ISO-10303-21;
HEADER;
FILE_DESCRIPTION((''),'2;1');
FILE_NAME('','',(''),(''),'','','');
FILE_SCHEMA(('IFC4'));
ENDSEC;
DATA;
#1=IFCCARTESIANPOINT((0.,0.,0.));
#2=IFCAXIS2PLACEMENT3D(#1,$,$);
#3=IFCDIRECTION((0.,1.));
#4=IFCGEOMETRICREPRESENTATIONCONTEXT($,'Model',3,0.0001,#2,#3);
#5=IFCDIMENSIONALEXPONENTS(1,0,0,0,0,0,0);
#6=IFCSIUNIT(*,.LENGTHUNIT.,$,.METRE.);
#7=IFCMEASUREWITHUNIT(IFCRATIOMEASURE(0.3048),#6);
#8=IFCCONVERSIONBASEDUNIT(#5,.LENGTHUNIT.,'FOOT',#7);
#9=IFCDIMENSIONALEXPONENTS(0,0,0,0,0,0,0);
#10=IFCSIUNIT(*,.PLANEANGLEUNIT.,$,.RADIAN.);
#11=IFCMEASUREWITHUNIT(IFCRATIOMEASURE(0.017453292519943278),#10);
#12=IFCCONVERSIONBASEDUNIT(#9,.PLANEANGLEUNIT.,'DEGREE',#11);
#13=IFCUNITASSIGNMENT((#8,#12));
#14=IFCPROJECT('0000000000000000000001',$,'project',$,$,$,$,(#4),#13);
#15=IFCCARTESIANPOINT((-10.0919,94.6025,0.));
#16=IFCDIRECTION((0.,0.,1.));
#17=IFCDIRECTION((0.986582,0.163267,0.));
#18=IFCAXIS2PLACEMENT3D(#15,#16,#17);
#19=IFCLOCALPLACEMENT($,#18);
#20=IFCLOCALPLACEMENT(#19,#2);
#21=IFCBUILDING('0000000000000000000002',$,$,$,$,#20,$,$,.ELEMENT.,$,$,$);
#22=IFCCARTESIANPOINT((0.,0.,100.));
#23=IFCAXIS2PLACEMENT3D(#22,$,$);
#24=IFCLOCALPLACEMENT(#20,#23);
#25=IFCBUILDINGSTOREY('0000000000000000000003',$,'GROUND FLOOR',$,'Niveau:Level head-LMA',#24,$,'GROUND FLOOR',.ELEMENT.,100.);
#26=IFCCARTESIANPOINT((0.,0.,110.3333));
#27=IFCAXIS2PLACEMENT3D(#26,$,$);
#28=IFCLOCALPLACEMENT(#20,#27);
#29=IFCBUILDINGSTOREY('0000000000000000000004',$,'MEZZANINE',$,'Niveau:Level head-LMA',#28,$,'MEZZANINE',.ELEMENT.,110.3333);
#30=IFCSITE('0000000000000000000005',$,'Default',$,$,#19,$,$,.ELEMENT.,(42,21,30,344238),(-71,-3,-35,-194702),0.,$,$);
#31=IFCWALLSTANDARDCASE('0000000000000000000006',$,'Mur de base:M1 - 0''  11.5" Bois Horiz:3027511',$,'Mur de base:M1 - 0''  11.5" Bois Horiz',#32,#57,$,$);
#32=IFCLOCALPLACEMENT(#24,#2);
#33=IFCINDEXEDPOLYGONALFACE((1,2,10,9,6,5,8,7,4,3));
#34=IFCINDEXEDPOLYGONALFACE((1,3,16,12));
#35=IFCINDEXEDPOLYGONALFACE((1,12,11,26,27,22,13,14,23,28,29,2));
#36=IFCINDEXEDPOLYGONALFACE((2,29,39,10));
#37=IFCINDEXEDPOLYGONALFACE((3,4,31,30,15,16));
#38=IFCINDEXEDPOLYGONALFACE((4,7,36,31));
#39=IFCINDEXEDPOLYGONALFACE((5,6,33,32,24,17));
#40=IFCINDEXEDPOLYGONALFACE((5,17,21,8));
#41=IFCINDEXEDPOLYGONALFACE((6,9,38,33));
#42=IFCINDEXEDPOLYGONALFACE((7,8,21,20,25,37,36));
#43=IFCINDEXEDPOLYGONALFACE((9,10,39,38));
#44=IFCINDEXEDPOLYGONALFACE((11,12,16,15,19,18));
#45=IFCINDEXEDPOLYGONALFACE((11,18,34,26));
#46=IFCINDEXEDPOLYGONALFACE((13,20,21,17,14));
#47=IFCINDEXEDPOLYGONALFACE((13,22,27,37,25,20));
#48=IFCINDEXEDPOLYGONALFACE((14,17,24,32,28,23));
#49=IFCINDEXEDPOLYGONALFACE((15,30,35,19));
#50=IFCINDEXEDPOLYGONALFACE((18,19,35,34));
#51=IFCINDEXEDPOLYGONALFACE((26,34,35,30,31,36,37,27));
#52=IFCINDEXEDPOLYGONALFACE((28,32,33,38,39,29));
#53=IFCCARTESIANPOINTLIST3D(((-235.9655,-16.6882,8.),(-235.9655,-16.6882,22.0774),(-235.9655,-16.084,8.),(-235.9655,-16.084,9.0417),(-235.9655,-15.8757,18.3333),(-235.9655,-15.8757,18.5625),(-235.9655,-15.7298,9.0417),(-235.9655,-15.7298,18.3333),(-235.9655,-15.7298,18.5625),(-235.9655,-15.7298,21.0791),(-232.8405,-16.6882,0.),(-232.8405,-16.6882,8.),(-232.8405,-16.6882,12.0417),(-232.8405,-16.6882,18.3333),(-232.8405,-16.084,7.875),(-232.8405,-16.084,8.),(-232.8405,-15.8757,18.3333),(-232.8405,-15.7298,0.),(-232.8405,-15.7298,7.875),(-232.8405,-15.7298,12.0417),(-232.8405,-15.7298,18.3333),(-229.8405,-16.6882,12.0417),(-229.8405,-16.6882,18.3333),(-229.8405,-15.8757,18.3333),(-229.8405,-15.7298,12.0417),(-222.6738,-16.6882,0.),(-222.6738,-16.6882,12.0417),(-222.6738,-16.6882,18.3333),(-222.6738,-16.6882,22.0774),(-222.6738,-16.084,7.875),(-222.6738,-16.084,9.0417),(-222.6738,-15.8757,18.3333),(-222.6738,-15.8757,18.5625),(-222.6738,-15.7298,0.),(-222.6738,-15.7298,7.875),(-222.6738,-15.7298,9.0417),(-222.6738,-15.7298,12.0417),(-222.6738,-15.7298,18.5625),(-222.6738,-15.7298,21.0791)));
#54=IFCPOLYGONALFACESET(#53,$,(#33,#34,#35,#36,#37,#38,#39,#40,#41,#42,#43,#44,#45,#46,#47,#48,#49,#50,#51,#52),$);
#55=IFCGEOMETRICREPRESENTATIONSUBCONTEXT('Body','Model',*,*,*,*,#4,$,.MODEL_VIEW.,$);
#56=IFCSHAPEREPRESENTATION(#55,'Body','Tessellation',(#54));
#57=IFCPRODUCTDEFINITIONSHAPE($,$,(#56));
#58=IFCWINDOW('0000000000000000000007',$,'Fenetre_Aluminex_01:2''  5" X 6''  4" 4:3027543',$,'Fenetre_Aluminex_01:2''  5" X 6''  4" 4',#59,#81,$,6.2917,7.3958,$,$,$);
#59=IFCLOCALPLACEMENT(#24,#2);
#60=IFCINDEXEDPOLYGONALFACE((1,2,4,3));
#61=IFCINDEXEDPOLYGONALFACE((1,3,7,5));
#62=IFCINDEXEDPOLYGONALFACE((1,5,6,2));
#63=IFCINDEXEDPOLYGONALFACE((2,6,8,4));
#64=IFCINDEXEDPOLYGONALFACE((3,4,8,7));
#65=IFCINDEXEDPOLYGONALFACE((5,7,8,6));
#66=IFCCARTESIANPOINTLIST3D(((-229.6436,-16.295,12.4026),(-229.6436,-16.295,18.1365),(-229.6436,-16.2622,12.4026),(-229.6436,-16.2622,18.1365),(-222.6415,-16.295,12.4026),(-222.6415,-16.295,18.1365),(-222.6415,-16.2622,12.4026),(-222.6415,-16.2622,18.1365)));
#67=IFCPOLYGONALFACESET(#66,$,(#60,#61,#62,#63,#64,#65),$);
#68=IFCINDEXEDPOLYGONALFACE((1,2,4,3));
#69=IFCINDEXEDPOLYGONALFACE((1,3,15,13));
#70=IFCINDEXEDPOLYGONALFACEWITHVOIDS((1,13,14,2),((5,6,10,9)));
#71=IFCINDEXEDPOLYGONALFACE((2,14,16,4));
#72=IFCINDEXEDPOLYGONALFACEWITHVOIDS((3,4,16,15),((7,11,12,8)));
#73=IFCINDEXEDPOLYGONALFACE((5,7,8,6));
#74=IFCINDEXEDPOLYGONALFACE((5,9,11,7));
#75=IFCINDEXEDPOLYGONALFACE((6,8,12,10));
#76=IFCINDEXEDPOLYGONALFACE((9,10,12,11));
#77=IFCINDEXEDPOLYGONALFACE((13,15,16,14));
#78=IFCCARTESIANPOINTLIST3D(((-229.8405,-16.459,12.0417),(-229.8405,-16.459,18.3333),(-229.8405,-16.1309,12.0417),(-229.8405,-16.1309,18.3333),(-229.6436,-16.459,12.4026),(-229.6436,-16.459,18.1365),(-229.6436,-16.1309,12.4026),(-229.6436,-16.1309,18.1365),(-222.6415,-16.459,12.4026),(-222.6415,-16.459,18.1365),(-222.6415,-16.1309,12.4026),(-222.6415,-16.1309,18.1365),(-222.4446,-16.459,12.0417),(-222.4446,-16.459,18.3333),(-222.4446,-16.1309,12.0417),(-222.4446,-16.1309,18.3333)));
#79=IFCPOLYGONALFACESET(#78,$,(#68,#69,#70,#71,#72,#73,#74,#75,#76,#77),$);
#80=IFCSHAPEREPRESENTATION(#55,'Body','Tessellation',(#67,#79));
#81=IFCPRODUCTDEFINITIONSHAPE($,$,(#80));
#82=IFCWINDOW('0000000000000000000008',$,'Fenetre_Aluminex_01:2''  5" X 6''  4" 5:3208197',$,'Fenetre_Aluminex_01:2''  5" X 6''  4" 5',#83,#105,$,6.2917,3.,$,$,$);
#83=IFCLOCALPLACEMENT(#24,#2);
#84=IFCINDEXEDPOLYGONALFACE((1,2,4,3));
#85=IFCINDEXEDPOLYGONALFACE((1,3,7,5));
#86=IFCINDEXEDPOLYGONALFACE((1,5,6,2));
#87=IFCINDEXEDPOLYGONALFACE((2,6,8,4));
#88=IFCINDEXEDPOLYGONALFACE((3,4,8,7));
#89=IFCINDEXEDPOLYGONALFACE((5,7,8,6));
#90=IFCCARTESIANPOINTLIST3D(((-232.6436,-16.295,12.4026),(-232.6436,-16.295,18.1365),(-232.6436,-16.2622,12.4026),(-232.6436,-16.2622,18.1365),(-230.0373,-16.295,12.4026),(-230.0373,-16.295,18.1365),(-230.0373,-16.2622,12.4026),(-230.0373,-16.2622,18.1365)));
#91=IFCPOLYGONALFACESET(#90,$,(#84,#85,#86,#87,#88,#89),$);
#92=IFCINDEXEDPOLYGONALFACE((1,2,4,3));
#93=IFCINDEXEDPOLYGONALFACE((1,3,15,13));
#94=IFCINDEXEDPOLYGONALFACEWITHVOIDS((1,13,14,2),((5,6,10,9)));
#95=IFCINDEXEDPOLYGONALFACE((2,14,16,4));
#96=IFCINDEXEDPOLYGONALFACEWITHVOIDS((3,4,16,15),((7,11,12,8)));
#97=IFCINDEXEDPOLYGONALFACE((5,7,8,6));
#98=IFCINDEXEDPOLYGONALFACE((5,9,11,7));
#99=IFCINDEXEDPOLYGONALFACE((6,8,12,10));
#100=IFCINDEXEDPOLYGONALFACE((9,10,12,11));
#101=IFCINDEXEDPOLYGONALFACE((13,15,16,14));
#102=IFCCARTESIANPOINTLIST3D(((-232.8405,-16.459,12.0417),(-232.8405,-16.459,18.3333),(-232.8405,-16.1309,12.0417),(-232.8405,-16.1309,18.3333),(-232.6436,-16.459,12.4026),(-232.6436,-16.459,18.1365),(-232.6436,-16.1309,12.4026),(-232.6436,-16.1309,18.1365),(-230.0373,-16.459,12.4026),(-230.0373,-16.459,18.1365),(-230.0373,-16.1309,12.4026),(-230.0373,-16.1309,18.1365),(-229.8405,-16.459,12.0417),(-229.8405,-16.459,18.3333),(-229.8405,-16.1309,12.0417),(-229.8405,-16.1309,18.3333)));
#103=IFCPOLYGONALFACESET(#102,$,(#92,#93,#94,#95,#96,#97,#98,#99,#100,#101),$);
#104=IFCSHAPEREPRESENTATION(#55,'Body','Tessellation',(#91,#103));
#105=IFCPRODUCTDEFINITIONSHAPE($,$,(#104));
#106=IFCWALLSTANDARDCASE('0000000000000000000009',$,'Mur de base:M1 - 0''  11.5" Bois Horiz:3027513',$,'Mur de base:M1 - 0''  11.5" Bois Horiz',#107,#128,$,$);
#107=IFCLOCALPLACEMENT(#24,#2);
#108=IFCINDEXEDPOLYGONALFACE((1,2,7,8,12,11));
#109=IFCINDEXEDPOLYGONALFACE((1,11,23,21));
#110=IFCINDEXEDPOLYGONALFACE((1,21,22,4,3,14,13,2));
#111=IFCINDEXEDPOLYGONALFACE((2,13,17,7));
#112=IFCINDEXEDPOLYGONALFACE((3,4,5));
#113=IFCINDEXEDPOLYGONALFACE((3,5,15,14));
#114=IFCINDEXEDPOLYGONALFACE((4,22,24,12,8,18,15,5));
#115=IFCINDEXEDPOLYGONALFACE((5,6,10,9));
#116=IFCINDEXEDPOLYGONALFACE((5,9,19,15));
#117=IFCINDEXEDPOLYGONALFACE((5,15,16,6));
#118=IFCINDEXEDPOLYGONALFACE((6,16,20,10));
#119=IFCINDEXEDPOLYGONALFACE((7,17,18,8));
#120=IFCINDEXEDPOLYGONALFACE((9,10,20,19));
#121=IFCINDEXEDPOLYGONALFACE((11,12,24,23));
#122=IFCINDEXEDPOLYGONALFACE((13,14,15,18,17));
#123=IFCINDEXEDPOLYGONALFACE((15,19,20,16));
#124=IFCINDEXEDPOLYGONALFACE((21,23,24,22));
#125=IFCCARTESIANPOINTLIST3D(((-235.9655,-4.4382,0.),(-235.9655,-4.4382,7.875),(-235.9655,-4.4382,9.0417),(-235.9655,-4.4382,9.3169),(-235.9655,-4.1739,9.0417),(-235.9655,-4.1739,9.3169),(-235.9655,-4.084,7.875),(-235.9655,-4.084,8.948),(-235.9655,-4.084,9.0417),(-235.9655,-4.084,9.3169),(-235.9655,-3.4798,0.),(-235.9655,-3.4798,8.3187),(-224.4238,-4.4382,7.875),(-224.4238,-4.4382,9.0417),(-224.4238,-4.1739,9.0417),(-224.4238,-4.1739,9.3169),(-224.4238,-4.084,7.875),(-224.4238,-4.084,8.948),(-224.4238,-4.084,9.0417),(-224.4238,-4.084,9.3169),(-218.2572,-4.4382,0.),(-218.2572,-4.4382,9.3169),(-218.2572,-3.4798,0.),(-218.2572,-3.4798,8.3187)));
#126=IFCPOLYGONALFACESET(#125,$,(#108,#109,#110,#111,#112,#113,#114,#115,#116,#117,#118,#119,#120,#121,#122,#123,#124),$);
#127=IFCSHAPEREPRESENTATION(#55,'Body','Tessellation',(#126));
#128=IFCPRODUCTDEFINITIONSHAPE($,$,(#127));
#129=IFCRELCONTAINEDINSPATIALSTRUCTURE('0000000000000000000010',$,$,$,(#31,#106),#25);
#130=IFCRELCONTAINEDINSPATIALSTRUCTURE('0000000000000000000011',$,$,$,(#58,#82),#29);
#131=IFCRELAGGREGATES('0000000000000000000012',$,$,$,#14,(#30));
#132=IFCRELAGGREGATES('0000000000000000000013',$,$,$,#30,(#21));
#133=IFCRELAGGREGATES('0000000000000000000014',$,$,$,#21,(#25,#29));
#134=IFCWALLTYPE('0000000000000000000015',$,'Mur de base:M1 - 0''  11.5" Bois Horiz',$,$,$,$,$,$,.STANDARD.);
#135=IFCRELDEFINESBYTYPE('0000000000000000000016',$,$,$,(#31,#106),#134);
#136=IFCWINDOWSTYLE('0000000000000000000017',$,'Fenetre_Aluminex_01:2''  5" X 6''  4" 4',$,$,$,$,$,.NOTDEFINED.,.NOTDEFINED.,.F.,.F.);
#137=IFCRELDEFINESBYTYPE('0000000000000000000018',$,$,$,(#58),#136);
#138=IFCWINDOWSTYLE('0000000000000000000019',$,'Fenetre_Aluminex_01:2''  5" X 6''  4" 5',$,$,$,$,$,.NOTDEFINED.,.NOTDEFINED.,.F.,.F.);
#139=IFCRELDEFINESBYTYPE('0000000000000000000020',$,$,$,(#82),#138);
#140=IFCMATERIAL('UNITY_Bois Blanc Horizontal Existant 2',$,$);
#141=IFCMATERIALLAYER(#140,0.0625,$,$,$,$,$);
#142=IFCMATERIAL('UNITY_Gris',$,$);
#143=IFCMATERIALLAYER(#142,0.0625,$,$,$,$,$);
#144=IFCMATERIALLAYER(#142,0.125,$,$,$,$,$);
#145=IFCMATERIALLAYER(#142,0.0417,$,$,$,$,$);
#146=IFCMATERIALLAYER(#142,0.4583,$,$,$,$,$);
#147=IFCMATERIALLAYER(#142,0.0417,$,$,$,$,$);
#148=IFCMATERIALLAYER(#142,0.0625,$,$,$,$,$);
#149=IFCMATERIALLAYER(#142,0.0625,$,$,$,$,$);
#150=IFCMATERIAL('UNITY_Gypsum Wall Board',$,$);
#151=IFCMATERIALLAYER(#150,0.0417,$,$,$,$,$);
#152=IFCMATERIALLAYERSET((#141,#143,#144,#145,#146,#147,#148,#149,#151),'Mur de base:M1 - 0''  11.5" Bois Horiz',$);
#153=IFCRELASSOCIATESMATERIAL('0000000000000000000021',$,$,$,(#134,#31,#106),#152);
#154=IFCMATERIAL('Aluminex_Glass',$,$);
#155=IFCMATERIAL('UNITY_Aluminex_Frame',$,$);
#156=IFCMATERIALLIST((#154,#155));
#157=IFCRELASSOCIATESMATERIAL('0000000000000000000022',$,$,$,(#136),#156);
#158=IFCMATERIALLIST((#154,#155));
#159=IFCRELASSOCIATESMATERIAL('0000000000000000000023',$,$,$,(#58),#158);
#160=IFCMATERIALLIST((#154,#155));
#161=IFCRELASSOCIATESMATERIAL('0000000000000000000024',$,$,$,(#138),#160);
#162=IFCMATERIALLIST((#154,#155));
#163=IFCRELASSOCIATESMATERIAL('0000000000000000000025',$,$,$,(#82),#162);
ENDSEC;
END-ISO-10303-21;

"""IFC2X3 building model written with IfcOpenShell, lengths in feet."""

from ifc_helpers import new_model, entity, si_unit, converted_unit, direction, frame, frame_2d, origin, place, context, subcontext, project, spatial, polyline, rectangle, outline, extrude, clip, bounded_halfspace, source, transform, mapped, material, material_list, layer, layer_set, layer_usage, type_object, type_shapes, element, fill, save


model = new_model("IFC2X3")

# Units and contexts
model_context = context("Model", 3, precision=0.0001, world=origin(), true_north=direction((0.0, 1.0)))
body_context = subcontext(model_context, "Body", "Model", "MODEL_VIEW")
ifc_project = project(units=[converted_unit("LENGTHUNIT", "FOOT", entity("IfcRatioMeasure", 0.3048), si_unit("LENGTHUNIT", "METRE"), dimensions=[1, 0, 0, 0, 0, 0, 0]), converted_unit("PLANEANGLEUNIT", "DEGREE", entity("IfcRatioMeasure", 0.017453292519943278), si_unit("PLANEANGLEUNIT", "RADIAN"), dimensions=[0, 0, 0, 0, 0, 0, 0])], contexts=[model_context])

# Site, building, storey
site_placement = place(None, frame((-10.0919, 94.6025, 0.0), z_axis=(0.0, 0.0, 1.0), x_axis=(0.986582, 0.163267, 0.0)))
site = spatial("IfcSite", under=ifc_project, at=site_placement, Name="Default", CompositionType="ELEMENT", RefLatitude=(42, 21, 30, 344238), RefLongitude=(-71, -3, -35, -194702), RefElevation=0.0)
building_placement = place(site_placement, origin())
building = spatial("IfcBuilding", under=site, at=building_placement, CompositionType="ELEMENT")
storey_1_placement = place(building_placement, frame((0.0, 0.0, 100.0)))
storey_1 = spatial("IfcBuildingStorey", under=building, at=storey_1_placement, Name="GROUND FLOOR", ObjectType="Niveau:Level head-LMA", LongName="GROUND FLOOR", CompositionType="ELEMENT", Elevation=100.0)

# Shared definitions
ifc_material_1 = material(Name="UNITY_Gris")
ifc_material_2 = material(Name="UNITY_Aluminex_Frame")

# Shared definitions
ifc_material_3 = material(Name="UNITY_Bois Blanc Horizontal Existant 2")
ifc_material_4 = material(Name="UNITY_Gypsum Wall Board")

# Wall, openings
ifc_layer_1 = layer(ifc_material_3, 0.0625)
ifc_layer_2 = layer(ifc_material_1, 0.0625)
ifc_layer_3 = layer(ifc_material_1, 0.125)
ifc_layer_4 = layer(ifc_material_1, 0.0417)
ifc_layer_5 = layer(ifc_material_1, 0.4583)
ifc_layer_6 = layer(ifc_material_1, 0.0417)
ifc_layer_7 = layer(ifc_material_1, 0.0625)
ifc_layer_8 = layer(ifc_material_1, 0.0625)
ifc_layer_9 = layer(ifc_material_4, 0.0417)
ifc_layer_set_1 = layer_set([ifc_layer_1, ifc_layer_2, ifc_layer_3, ifc_layer_4, ifc_layer_5, ifc_layer_6, ifc_layer_7, ifc_layer_8, ifc_layer_9], Name="Mur de base:M1 - 0'  11.5\" Bois Horiz")
ifc_layer_usage_1 = layer_usage(ifc_layer_set_1, "AXIS2", "NEGATIVE", 0.4792)
wall_type_1 = type_object("IfcWallType", Name="Mur de base:M1 - 0'  11.5\" Bois Horiz", PredefinedType="STANDARD", material=ifc_layer_set_1)
wall_1_placement = place(storey_1_placement, frame((-222.6738, -16.209, 0.0), z_axis=(0.0, 0.0, 1.0), x_axis=(-1.0, 0.0, 0.0)))
wall_1 = element("IfcWallStandardCase", 1, at=wall_1_placement, inside=storey_1, type_object=wall_type_1, material=ifc_layer_usage_1, Name="Mur de base:M1 - 0'  11.5\" Bois Horiz:3027511", ObjectType="Mur de base:M1 - 0'  11.5\" Bois Horiz", context=body_context, shape_type="Clipping", body=[
    clip(clip(clip(extrude(rectangle(XDim=13.2917, YDim=0.9583, at=frame_2d((6.6458, 0.0), x_axis=(-1.0, 0.0))), origin(), (0.0, 0.0, 1.0), 22.0774), bounded_halfspace(frame((0.0, -0.4792, 21.0791), z_axis=(0.0, -0.721387, 0.692532), x_axis=(1.0, 0.0, 0.0)), False, frame((0.0, -0.4792, 21.0791)), polyline([(0.0, 0.0), (13.2917, 0.0), (13.2917, 0.2708), (13.2917, 0.9583), (0.0, 0.9583), (0.0, 0.0)]))), bounded_halfspace(frame((13.2917, -0.125, 9.0417), z_axis=(0.0, 1.0, 0.0), x_axis=(0.0, 0.0, 1.0)), True, frame((13.2917, -0.125, 9.0417), z_axis=(0.0, 1.0, 0.0), x_axis=(0.0, 0.0, 1.0)), polyline([(0.0, 0.0), (-1.0417, 0.0), (-1.0417, -3.125), (-1.1667, -3.125), (-1.1667, -13.2917), (0.0, -13.2917), (0.0, 0.0)]))), bounded_halfspace(frame((10.1666, -0.3333, 18.3333), z_axis=(0.0, 1.0, 0.0), x_axis=(0.0, 0.0, -1.0)), True, frame((10.1666, -0.3333, 18.3333), z_axis=(0.0, 1.0, 0.0), x_axis=(0.0, 0.0, -1.0)), polyline([(0.0, 0.0), (0.0, 10.1666), (-0.2292, 10.1666), (-0.2292, -3.125), (0.0, -3.125), (0.0, 0.0)]))),
])
opening_1_placement = place(wall_1_placement, origin())
element("IfcOpeningElement", 2, at=opening_1_placement, cuts=wall_1, ObjectType="Opening", context=body_context, shape_type="SweptSolid", body=[
    extrude(rectangle(XDim=6.2917, YDim=0.6875, at=frame_2d((0.0, 0.0), x_axis=(0.0, 1.0))), frame((-0.3438, 0.25, 15.1875), z_axis=(0.0, 1.0, 0.0), x_axis=(1.0, 0.0, 0.0)), (0.0, 0.0, 1.0), 3.0),
])
opening_2_placement = place(wall_1_placement, origin())
element("IfcOpeningElement", 3, at=opening_2_placement, cuts=wall_1, ObjectType="Opening", context=body_context, shape_type="SweptSolid", body=[
    extrude(rectangle(XDim=8.0, YDim=0.6667, at=frame_2d((0.0, 0.0), x_axis=(0.0, 1.0))), frame((13.6666, -3.0, 4.0), z_axis=(0.0, 1.0, 0.0), x_axis=(-1.0, 0.0, 0.0)), (0.0, 0.0, 1.0), 2.875),
])
opening_3_placement = place(wall_1_placement, frame((-222.6738, -16.209, 0.0), z_axis=(0.0, 0.0, 1.0), x_axis=(-1.0, 0.0, 0.0)))
element("IfcOpeningElement", 4, at=opening_3_placement, cuts=wall_1, ObjectType="Opening", context=body_context, shape_type="SweptSolid", body=[
    extrude(rectangle(XDim=8.0, YDim=3.1667, at=frame_2d((0.0, 0.0), x_axis=(0.0, 1.0))), frame((-234.4238, -11.6882, 4.0), z_axis=(0.0, -1.0, 0.0), x_axis=(1.0, 0.0, 0.0)), (0.0, 0.0, 1.0), 10.0),
])
opening_4_placement = place(wall_1_placement, frame((-0.2292, -0.4792, 12.0417)))
opening_4 = element("IfcOpeningElement", 5, at=opening_4_placement, cuts=wall_1, ObjectType="Opening", context=body_context, shape_type="SweptSolid", body=[
    extrude(rectangle(XDim=6.2917, YDim=7.3958, at=frame_2d((3.1458, 3.6979), x_axis=(1.0, 0.0))), frame((0.0, 0.0, 0.0), z_axis=(0.0, 1.0, 0.0), x_axis=(0.0, 0.0, 1.0)), (0.0, 0.0, 1.0), 0.9583),
])
opening_5_placement = place(wall_1_placement, frame((7.1666, -0.4792, 12.0417)))
opening_5 = element("IfcOpeningElement", 6, at=opening_5_placement, cuts=wall_1, ObjectType="Opening", context=body_context, shape_type="SweptSolid", body=[
    extrude(rectangle(XDim=6.2917, YDim=3.0, at=frame_2d((3.1458, 1.5), x_axis=(1.0, 0.0))), frame((0.0, 0.0, 0.0), z_axis=(0.0, 1.0, 0.0), x_axis=(0.0, 0.0, 1.0)), (0.0, 0.0, 1.0), 0.9583),
])

# Shared definitions
storey_2_placement = place(building_placement, frame((0.0, 0.0, 110.3333)))
storey_2 = spatial("IfcBuildingStorey", under=building, at=storey_2_placement, Name="MEZZANINE", ObjectType="Niveau:Level head-LMA", LongName="MEZZANINE", CompositionType="ELEMENT", Elevation=110.3333)

# Windows
ifc_material_5 = material(Name="Aluminex_Glass")
ifc_material_list_1 = material_list([ifc_material_5, ifc_material_2])
ifc_material_list_2 = material_list([ifc_material_5, ifc_material_2])
window_style_1 = type_object("IfcWindowStyle", Name="Fenetre_Aluminex_01:2'  5\" X 6'  4\" 4", ConstructionType="NOTDEFINED", OperationType="NOTDEFINED", ParameterTakesPrecedence=False, Sizeable=False, material=ifc_material_list_2)
shared_shape_1 = source(origin(), body_context, "Body", "SweptSolid", [
    extrude(rectangle(XDim=0.0328, YDim=7.0021, at=frame_2d((0.0, 0.0), x_axis=(1.0, 0.0))), frame((3.6979, 0.5487, 0.3609), z_axis=(0.0, 0.0, 1.0), x_axis=(0.0, 1.0, 0.0)), (0.0, 0.0, 1.0), 5.7339),
    extrude(outline(polyline([(-3.6979, -3.1458), (3.6979, -3.1458), (3.6979, 3.1458), (-3.6979, 3.1458), (-3.6979, -3.1458)]), holes=[polyline([(-3.5011, -2.949), (-3.5011, 2.7849), (3.5011, 2.7849), (3.5011, -2.949), (-3.5011, -2.949)])]), frame((3.6979, 0.4011, 3.1458), z_axis=(0.0, 1.0, 0.0), x_axis=(1.0, 0.0, 0.0)), (0.0, 0.0, 1.0), 0.3281),
])
type_shapes(window_style_1, [shared_shape_1])
window_1_placement = place(opening_4_placement, origin())
window_1 = element("IfcWindow", 7, at=window_1_placement, inside=storey_2, type_object=window_style_1, material=ifc_material_list_1, Name="Fenetre_Aluminex_01:2'  5\" X 6'  4\" 4:3027543", ObjectType="Fenetre_Aluminex_01:2'  5\" X 6'  4\" 4", OverallHeight=6.2917, OverallWidth=7.3958, context=body_context, shape_type="MappedRepresentation", body=[
    mapped(shared_shape_1, transform((0.0, 0.0, 0.0), scale=1.0)),
])
fill(opening_4, window_1)
ifc_material_list_3 = material_list([ifc_material_5, ifc_material_2])
ifc_material_list_4 = material_list([ifc_material_5, ifc_material_2])
window_style_2 = type_object("IfcWindowStyle", Name="Fenetre_Aluminex_01:2'  5\" X 6'  4\" 5", ConstructionType="NOTDEFINED", OperationType="NOTDEFINED", ParameterTakesPrecedence=False, Sizeable=False, material=ifc_material_list_4)
shared_shape_2 = source(origin(), body_context, "Body", "SweptSolid", [
    extrude(rectangle(XDim=0.0328, YDim=2.6063, at=frame_2d((0.0, 0.0), x_axis=(1.0, 0.0))), frame((1.5, 0.5487, 0.3609), z_axis=(0.0, 0.0, 1.0), x_axis=(0.0, 1.0, 0.0)), (0.0, 0.0, 1.0), 5.7339),
    extrude(outline(polyline([(-1.5, -3.1458), (1.5, -3.1458), (1.5, 3.1458), (-1.5, 3.1458), (-1.5, -3.1458)]), holes=[polyline([(-1.3031, -2.949), (-1.3031, 2.7849), (1.3031, 2.7849), (1.3031, -2.949), (-1.3031, -2.949)])]), frame((1.5, 0.4011, 3.1458), z_axis=(0.0, 1.0, 0.0), x_axis=(1.0, 0.0, 0.0)), (0.0, 0.0, 1.0), 0.3281),
])
type_shapes(window_style_2, [shared_shape_2])
window_2_placement = place(opening_5_placement, origin())
window_2 = element("IfcWindow", 8, at=window_2_placement, inside=storey_2, type_object=window_style_2, material=ifc_material_list_3, Name="Fenetre_Aluminex_01:2'  5\" X 6'  4\" 5:3208197", ObjectType="Fenetre_Aluminex_01:2'  5\" X 6'  4\" 5", OverallHeight=6.2917, OverallWidth=3.0, context=body_context, shape_type="MappedRepresentation", body=[
    mapped(shared_shape_2, transform((0.0, 0.0, 0.0), scale=1.0)),
])
fill(opening_5, window_2)

# Wall, opening
ifc_layer_usage_2 = layer_usage(ifc_layer_set_1, "AXIS2", "NEGATIVE", 0.4792)
wall_2_placement = place(storey_1_placement, frame((-235.9655, -3.959, 0.0)))
wall_2 = element("IfcWallStandardCase", 9, at=wall_2_placement, inside=storey_1, type_object=wall_type_1, material=ifc_layer_usage_2, Name="Mur de base:M1 - 0'  11.5\" Bois Horiz:3027513", ObjectType="Mur de base:M1 - 0'  11.5\" Bois Horiz", context=body_context, shape_type="Clipping", body=[
    clip(extrude(rectangle(XDim=17.7083, YDim=0.9583, at=frame_2d((8.8542, 0.0), x_axis=(-1.0, 0.0))), origin(), (0.0, 0.0, 1.0), 9.3169), bounded_halfspace(frame((0.0, -0.4792, 9.3169), z_axis=(0.0, 0.721387, 0.692532), x_axis=(-1.0, 0.0, 0.0)), False, frame((0.0, -0.4792, 9.3169)), polyline([(0.0, 0.0), (11.3333, 0.0), (11.75, 0.0), (16.75, 0.0), (17.7083, 0.0), (17.7083, 0.9583), (0.0, 0.9583), (0.0, 0.3542), (11.5417, 0.3542), (11.5417, 0.2643), (0.0, 0.2643), (0.0, 0.0)]))),
])
opening_6_placement = place(storey_1_placement, frame((-235.9655, -3.959, 0.0)))
element("IfcOpeningElement", 10, at=opening_6_placement, cuts=wall_2, ObjectType="Opening", context=body_context, shape_type="SweptSolid", body=[
    extrude(rectangle(XDim=0.3542, YDim=11.5417, at=frame_2d((0.0, 0.0), x_axis=(1.0, 0.0))), frame((5.7708, -0.3021, 7.875), z_axis=(0.0, 0.0, 1.0), x_axis=(0.0, 1.0, 0.0)), (0.0, 0.0, 1.0), 1.1667),
])

save(model, "model.ifc")
